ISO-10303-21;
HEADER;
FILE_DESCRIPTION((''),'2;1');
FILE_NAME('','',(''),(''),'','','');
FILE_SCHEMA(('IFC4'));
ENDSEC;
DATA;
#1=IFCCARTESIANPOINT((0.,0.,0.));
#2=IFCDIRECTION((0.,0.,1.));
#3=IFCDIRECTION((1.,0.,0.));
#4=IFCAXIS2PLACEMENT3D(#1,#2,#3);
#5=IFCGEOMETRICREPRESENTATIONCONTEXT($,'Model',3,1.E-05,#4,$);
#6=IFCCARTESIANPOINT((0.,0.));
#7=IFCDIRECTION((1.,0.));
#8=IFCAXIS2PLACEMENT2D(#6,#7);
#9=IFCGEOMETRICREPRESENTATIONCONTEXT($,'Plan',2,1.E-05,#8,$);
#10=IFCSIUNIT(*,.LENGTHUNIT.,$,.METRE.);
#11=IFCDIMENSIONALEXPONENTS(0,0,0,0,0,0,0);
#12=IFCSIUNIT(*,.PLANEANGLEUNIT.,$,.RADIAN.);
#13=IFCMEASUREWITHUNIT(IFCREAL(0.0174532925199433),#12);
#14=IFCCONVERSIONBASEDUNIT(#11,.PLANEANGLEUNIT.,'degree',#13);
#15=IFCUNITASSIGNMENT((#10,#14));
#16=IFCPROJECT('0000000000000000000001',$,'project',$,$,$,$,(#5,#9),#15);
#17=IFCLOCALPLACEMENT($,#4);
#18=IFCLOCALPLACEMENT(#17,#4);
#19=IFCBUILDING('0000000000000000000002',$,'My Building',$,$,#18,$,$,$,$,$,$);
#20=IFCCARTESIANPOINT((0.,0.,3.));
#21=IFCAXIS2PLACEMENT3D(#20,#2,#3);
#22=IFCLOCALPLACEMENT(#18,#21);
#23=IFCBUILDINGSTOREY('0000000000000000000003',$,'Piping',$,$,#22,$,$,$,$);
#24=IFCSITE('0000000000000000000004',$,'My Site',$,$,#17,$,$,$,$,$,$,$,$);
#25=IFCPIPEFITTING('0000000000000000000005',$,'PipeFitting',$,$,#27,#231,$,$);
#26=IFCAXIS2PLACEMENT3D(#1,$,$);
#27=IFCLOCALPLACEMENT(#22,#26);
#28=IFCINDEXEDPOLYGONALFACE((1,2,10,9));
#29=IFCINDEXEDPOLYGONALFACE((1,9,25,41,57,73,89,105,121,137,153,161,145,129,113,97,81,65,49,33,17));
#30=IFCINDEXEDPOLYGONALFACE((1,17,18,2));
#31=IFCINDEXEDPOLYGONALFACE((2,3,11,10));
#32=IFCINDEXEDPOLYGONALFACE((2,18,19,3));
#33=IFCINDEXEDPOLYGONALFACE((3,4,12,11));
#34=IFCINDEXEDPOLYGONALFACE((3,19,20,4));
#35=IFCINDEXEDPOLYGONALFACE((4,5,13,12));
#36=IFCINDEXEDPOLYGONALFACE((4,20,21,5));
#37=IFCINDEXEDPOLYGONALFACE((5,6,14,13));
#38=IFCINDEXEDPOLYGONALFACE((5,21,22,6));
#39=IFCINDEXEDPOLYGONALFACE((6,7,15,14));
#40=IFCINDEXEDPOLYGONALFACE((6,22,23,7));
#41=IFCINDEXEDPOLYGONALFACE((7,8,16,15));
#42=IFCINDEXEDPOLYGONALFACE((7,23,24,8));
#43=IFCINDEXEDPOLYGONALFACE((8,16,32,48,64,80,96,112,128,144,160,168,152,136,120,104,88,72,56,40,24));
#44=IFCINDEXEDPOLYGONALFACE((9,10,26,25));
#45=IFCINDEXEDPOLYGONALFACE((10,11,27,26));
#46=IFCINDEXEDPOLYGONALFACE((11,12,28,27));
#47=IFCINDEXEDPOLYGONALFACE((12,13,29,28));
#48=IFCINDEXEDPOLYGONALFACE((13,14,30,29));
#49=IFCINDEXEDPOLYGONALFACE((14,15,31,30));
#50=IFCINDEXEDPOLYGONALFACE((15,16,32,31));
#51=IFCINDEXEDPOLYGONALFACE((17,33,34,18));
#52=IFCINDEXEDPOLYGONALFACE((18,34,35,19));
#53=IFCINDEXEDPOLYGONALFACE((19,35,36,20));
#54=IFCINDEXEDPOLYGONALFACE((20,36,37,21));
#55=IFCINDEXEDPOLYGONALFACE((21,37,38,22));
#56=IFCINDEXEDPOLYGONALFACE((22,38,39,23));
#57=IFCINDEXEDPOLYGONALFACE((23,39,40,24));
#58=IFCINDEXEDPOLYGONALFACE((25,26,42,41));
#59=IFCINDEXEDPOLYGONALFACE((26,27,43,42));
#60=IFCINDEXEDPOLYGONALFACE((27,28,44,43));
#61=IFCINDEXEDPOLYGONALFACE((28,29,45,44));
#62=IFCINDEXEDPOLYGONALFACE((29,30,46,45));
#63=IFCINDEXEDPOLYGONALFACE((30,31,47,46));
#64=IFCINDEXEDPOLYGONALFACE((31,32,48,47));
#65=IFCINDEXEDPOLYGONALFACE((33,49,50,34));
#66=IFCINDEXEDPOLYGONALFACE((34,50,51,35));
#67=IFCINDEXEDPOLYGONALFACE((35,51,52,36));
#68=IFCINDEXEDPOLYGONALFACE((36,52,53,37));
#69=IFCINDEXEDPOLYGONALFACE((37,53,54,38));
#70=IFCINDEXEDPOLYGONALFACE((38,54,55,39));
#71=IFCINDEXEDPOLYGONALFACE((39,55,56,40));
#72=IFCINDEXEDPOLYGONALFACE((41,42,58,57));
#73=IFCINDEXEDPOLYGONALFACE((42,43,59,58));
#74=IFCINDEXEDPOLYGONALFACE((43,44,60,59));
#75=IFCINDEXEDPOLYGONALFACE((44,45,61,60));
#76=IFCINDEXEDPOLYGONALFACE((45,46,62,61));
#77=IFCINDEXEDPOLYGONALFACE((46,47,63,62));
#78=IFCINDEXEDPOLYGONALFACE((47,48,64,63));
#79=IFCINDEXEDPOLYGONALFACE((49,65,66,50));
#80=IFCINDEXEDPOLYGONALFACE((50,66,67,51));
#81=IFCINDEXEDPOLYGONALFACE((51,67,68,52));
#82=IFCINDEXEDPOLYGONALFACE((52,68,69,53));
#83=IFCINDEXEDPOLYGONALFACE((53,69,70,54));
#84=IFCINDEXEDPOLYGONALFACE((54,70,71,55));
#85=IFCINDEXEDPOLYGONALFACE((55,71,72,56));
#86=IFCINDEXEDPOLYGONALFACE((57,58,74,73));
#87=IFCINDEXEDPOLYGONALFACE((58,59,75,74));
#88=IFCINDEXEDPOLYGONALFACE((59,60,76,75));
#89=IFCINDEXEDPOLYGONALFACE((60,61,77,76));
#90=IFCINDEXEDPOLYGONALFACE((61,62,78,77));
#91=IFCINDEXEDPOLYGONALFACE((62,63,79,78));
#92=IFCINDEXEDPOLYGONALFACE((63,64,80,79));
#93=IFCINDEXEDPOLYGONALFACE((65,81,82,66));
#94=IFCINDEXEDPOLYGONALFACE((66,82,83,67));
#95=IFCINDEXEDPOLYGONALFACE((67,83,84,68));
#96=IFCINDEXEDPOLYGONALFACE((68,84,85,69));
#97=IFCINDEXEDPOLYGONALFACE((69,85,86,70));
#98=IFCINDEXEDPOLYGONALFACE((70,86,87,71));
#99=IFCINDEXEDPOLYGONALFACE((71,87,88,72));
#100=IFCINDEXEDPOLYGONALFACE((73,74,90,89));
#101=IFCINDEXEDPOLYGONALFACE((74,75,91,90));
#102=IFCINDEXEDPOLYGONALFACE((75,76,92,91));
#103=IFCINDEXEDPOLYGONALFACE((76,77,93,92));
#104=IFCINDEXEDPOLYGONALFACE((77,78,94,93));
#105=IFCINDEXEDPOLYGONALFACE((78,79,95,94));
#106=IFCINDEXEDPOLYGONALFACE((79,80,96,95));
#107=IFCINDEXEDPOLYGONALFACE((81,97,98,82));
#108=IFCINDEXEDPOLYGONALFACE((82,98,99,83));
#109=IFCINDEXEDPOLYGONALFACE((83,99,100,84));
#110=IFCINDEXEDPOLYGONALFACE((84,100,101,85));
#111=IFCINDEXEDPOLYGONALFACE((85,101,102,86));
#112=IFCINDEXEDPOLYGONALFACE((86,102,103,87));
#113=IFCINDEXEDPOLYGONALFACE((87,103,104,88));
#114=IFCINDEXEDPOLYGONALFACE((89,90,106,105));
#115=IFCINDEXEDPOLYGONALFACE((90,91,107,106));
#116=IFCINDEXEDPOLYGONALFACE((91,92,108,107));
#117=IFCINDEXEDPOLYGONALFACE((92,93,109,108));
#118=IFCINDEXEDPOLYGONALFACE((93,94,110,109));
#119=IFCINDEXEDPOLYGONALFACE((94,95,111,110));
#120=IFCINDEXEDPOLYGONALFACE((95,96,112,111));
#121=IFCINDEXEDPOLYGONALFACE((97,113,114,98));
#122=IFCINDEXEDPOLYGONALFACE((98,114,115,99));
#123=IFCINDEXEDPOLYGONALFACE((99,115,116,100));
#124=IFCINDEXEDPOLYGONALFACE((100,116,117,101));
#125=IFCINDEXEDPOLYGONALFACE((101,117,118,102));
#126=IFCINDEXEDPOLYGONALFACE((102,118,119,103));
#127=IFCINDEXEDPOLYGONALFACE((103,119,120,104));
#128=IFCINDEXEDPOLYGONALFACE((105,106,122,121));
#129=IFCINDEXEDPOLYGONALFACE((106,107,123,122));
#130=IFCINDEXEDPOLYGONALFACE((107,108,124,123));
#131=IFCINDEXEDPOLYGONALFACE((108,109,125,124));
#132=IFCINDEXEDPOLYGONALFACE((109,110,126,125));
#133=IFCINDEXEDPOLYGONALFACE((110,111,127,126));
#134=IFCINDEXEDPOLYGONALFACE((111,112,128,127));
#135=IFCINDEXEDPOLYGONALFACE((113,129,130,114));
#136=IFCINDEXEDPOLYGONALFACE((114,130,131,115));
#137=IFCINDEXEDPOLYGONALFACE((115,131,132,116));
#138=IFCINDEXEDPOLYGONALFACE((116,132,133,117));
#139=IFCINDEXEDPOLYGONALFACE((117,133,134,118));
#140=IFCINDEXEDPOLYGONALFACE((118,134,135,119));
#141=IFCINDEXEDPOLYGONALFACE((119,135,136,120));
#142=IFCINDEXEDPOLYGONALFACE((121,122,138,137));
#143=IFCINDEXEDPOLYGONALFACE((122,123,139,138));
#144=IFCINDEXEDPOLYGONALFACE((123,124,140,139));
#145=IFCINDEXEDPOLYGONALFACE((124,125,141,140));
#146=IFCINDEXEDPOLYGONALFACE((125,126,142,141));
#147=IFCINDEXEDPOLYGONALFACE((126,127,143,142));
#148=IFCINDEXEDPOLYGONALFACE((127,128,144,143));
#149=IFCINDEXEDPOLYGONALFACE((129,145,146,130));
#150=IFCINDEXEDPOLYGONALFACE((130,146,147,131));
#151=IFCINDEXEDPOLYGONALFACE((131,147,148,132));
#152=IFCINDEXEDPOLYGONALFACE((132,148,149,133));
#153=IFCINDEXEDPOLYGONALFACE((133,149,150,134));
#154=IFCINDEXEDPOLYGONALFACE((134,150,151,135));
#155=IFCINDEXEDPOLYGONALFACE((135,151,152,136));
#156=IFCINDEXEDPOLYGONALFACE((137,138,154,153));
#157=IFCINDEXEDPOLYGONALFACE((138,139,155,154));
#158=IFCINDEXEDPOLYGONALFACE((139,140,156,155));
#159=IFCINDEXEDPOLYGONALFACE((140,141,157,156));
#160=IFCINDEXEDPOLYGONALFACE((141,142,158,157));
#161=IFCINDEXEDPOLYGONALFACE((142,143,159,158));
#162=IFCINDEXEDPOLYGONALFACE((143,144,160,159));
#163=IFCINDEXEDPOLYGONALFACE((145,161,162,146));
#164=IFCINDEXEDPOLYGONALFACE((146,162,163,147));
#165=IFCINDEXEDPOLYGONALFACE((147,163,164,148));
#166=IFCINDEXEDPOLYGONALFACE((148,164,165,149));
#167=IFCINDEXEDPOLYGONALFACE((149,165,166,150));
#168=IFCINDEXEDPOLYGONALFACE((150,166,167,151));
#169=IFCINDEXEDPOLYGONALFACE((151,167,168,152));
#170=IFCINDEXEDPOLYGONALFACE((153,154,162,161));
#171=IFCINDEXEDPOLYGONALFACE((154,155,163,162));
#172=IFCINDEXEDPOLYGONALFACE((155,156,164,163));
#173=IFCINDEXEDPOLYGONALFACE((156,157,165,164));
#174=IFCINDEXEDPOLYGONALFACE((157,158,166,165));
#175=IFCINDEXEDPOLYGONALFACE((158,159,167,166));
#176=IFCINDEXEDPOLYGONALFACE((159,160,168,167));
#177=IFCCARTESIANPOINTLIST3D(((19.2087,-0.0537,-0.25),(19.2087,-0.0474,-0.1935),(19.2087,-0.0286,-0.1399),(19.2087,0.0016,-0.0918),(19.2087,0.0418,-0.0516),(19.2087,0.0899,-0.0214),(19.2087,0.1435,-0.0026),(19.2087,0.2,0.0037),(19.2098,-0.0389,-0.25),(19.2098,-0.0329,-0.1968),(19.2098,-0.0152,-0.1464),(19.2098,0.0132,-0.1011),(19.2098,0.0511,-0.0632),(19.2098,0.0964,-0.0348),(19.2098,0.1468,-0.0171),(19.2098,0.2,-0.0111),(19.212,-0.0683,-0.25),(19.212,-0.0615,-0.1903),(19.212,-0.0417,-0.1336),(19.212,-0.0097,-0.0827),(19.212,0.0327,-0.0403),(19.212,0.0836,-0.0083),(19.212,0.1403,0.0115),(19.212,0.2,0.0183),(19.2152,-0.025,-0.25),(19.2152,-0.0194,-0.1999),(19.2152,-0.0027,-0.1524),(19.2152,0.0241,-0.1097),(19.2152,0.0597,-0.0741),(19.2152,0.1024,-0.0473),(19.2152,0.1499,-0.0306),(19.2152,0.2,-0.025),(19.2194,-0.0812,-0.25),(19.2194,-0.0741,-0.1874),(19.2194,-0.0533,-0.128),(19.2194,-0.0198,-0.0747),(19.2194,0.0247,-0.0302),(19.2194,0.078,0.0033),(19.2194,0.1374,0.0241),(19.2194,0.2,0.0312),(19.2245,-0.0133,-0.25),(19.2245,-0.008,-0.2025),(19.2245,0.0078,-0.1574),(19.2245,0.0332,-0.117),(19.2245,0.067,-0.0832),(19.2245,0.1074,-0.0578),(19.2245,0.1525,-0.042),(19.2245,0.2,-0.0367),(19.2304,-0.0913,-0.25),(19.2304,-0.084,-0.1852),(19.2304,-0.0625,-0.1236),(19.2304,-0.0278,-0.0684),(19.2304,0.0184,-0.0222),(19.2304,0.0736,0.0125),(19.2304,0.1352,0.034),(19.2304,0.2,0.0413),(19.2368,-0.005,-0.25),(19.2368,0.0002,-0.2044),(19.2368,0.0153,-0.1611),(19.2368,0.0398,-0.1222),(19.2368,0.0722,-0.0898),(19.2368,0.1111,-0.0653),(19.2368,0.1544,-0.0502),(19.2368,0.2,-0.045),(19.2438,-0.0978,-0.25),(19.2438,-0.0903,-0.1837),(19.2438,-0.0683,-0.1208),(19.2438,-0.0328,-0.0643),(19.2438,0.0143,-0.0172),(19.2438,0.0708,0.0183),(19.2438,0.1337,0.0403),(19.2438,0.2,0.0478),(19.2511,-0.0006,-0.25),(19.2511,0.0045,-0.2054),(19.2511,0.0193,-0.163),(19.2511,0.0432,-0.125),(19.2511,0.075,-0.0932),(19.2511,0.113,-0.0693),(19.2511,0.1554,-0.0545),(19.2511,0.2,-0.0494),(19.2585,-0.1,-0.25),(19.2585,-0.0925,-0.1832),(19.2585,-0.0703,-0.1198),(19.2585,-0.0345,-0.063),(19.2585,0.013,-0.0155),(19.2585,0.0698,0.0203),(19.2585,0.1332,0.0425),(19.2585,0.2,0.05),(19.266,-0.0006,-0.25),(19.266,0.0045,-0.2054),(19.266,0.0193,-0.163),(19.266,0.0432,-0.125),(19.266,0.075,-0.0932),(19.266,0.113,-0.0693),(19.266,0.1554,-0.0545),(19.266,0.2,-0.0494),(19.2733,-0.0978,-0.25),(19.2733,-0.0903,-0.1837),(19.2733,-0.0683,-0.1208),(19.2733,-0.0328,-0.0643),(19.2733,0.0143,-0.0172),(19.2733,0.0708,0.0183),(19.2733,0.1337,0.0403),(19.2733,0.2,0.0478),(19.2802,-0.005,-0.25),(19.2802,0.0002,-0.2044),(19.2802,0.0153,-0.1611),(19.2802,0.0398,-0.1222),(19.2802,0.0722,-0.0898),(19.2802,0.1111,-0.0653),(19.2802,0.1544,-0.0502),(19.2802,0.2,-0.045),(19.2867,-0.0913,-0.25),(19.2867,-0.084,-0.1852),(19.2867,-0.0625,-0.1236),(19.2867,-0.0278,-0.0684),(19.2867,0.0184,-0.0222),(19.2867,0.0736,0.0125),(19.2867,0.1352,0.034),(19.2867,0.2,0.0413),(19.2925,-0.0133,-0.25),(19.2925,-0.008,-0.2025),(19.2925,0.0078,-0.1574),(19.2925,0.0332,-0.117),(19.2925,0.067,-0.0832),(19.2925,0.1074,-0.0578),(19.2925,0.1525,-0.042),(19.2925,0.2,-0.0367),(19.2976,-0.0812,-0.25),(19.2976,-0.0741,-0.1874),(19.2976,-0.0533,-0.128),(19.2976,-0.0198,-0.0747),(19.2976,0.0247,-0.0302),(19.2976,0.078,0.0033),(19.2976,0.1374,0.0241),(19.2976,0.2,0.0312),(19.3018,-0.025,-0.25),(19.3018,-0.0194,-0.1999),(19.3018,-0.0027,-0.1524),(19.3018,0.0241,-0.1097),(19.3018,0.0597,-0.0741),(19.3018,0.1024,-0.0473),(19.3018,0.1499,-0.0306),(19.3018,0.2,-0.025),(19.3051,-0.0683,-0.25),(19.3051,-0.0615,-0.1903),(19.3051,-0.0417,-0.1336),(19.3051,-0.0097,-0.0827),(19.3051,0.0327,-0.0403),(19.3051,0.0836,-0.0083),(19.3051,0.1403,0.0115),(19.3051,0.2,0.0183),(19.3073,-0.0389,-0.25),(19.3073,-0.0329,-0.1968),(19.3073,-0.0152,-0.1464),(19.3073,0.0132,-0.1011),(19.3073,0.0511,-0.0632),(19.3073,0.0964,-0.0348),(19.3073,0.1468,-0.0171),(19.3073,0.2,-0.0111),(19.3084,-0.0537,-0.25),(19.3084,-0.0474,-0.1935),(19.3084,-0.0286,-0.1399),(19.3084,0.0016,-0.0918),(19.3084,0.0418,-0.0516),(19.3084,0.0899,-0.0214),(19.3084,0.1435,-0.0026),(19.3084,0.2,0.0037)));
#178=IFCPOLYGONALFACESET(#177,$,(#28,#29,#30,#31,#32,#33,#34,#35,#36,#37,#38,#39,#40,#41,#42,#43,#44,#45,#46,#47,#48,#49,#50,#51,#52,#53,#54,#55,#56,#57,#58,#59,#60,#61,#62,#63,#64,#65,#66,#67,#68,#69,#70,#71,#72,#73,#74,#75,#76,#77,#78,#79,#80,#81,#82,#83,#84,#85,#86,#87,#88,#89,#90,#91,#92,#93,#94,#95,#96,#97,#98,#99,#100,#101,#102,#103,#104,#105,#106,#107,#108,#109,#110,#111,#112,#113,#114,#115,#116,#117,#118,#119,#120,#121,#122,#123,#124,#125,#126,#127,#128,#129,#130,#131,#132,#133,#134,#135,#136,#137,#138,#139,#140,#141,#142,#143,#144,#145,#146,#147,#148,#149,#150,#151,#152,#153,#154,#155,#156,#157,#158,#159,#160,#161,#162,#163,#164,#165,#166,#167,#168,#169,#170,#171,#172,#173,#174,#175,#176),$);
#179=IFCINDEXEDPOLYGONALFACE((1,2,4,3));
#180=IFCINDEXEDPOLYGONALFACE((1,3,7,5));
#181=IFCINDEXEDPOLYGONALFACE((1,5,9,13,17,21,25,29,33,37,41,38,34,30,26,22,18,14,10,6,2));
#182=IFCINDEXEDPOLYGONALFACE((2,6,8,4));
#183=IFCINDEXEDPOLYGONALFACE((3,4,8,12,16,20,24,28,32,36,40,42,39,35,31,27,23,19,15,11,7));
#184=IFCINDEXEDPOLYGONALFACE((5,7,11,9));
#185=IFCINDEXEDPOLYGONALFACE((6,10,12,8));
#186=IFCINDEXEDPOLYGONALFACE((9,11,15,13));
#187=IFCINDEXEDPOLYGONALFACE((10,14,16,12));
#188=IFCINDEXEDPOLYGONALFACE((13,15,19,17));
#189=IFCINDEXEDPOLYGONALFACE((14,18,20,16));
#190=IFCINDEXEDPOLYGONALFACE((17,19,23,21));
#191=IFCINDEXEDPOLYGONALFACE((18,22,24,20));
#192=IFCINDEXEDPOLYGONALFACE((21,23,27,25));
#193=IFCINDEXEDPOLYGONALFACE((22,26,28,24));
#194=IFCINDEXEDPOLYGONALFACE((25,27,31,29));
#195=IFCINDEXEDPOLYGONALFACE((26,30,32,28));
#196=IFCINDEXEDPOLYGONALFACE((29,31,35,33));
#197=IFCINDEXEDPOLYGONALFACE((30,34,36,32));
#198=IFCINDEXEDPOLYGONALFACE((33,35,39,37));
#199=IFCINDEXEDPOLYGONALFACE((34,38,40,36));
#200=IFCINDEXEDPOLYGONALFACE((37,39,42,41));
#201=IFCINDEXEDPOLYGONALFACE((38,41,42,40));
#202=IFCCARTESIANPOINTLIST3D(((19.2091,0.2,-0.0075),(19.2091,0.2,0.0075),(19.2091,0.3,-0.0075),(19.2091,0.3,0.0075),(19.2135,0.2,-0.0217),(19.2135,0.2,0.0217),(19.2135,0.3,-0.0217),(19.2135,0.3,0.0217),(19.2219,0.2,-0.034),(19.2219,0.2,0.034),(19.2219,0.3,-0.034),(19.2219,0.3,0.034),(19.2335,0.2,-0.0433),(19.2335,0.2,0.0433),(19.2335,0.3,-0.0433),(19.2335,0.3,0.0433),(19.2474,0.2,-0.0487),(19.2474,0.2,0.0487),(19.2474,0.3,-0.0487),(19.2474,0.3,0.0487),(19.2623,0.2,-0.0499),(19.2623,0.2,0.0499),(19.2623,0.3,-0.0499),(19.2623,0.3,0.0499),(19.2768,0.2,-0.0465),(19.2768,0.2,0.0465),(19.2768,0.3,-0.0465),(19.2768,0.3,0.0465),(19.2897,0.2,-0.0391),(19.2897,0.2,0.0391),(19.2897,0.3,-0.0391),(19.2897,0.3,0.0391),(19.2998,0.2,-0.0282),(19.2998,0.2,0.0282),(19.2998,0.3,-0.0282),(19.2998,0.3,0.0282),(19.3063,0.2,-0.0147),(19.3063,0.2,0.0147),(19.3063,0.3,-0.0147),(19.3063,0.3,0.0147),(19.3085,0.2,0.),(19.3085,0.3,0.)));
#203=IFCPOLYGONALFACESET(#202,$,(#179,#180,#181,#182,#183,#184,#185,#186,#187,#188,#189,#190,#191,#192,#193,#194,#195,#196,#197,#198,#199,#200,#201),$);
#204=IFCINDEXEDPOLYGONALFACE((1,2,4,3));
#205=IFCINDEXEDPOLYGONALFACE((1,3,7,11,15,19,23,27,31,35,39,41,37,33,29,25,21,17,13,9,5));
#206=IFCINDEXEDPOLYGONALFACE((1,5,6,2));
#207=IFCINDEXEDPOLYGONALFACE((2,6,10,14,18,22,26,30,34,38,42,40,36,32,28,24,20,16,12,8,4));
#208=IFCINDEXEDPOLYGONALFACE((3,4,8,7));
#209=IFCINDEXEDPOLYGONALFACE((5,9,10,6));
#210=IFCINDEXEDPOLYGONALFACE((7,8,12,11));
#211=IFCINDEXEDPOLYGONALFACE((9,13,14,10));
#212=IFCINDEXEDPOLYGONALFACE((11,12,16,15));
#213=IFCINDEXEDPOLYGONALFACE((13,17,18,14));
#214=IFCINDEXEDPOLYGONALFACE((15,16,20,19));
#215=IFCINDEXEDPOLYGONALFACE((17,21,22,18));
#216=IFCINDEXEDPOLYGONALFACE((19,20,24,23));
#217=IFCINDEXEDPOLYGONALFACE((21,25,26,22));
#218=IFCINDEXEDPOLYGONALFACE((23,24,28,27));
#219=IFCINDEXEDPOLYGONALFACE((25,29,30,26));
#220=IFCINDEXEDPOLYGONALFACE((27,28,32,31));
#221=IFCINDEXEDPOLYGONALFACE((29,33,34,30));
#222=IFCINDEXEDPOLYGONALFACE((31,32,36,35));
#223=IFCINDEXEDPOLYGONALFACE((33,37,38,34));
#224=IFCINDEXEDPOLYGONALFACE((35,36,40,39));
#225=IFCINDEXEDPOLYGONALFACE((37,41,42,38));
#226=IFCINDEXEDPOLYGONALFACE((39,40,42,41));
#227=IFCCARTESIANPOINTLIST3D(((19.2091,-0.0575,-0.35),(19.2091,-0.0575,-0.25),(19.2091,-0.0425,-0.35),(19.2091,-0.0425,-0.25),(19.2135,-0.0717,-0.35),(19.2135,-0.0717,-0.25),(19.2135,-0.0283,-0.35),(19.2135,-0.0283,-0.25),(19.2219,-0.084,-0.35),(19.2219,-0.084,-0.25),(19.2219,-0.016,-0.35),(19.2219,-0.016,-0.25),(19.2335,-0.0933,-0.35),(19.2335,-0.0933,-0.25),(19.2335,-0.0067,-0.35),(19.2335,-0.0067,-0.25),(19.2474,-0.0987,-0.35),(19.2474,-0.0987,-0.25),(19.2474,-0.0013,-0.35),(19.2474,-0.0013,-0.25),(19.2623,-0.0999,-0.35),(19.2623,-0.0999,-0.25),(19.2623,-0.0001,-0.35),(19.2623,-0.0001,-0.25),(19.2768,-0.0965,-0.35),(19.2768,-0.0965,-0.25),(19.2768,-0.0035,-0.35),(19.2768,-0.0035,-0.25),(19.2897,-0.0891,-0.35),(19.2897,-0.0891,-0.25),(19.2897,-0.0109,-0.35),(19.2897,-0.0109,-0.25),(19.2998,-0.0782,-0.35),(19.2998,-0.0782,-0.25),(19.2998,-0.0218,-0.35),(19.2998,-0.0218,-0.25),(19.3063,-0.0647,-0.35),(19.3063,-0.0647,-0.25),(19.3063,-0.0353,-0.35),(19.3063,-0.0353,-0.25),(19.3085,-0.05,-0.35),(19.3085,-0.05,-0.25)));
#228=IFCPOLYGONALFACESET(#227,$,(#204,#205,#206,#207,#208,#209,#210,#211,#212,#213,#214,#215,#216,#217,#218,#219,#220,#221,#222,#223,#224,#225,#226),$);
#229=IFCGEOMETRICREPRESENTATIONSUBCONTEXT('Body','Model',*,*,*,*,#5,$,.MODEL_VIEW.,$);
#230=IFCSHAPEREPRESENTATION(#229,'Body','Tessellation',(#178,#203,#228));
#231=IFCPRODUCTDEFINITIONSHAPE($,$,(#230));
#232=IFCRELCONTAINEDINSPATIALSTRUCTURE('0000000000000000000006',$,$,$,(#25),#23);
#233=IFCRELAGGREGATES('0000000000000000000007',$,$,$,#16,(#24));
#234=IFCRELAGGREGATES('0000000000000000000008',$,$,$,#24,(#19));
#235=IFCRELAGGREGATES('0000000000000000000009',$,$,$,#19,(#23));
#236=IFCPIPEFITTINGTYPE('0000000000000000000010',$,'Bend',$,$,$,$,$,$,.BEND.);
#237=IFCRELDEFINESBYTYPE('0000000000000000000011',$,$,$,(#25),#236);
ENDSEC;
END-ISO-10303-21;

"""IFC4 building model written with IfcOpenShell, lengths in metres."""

from ifc_helpers import new_model, entity, si_unit, converted_unit, frame, origin_with_axes, origin_2d_with_axis, place, context, subcontext, project, spatial, circle, extrude, source, transform, mapped, type_object, type_shapes, element, save


model = new_model("IFC4")

# Units and contexts
model_context = context("Model", 3, precision=1e-05, world=origin_with_axes())
plan_context = context("Plan", 2, precision=1e-05, world=origin_2d_with_axis())
body_context = subcontext(model_context, "Body", "Model", "MODEL_VIEW")
ifc_project = project(units=[si_unit("LENGTHUNIT", "METRE"), converted_unit("PLANEANGLEUNIT", "degree", entity("IfcReal", 0.0174532925199433), si_unit("PLANEANGLEUNIT", "RADIAN"), dimensions=[0, 0, 0, 0, 0, 0, 0])], contexts=[model_context, plan_context])

# Site, building, storey
site_placement = place(None, origin_with_axes())
site = spatial("IfcSite", under=ifc_project, at=site_placement, Name="My Site")
building_placement = place(site_placement, origin_with_axes())
building = spatial("IfcBuilding", under=site, at=building_placement, Name="My Building")
storey_placement = place(building_placement, frame((0.0, 0.0, 3.0), z_axis=(0.0, 0.0, 1.0), x_axis=(1.0, 0.0, 0.0)))
storey = spatial("IfcBuildingStorey", under=building, at=storey_placement, Name="Piping")

# Shared definitions
pipe_fitting_type = type_object("IfcPipeFittingType", Name="Bend", PredefinedType="BEND")
shared_shape = source(origin_with_axes(), body_context, "Body", "SolidModel", [
    entity("IfcSweptDiskSolid", entity("IfcIndexedPolyCurve", entity("IfcCartesianPointList3D", [[0.0, 0.0, -0.1], [0.0, 0.0732, -0.2768], [0.0, 0.25, -0.35]]), [entity("IfcArcIndex", [1, 2, 3])]), 0.05),
    extrude(circle(Radius=0.05), origin_with_axes(), (0.0, 0.0, -1.0), 0.1),
    extrude(circle(Radius=0.05), frame((0.0, 0.25, -0.35), z_axis=(0.0, 1.0, 0.0), x_axis=(1.0, 0.0, 0.0)), (0.0, 0.0, 1.0), 0.1),
])
type_shapes(pipe_fitting_type, [shared_shape])

# Pipe fitting
for number, where, z_axis, x_axis, name in (
    (1, (19.2585, 0.3, 0.0), (0.0, 1.0, 0.0), (1.0, 0.0, 0.0), "PipeFitting"),
):
    element("IfcPipeFitting", number, at=place(storey_placement, frame(where, z_axis=z_axis, x_axis=x_axis)), inside=storey, type_object=pipe_fitting_type, Name=name, context=body_context, shape_type="MappedRepresentation", body=[
        mapped(shared_shape, transform((0.0, 0.0, 0.0), x_axis=(1.0, 0.0, 0.0), y_axis=(0.0, 1.0, 0.0), z_axis=(0.0, 0.0, 1.0), scale=1.0)),
    ])

save(model, "model.ifc")
